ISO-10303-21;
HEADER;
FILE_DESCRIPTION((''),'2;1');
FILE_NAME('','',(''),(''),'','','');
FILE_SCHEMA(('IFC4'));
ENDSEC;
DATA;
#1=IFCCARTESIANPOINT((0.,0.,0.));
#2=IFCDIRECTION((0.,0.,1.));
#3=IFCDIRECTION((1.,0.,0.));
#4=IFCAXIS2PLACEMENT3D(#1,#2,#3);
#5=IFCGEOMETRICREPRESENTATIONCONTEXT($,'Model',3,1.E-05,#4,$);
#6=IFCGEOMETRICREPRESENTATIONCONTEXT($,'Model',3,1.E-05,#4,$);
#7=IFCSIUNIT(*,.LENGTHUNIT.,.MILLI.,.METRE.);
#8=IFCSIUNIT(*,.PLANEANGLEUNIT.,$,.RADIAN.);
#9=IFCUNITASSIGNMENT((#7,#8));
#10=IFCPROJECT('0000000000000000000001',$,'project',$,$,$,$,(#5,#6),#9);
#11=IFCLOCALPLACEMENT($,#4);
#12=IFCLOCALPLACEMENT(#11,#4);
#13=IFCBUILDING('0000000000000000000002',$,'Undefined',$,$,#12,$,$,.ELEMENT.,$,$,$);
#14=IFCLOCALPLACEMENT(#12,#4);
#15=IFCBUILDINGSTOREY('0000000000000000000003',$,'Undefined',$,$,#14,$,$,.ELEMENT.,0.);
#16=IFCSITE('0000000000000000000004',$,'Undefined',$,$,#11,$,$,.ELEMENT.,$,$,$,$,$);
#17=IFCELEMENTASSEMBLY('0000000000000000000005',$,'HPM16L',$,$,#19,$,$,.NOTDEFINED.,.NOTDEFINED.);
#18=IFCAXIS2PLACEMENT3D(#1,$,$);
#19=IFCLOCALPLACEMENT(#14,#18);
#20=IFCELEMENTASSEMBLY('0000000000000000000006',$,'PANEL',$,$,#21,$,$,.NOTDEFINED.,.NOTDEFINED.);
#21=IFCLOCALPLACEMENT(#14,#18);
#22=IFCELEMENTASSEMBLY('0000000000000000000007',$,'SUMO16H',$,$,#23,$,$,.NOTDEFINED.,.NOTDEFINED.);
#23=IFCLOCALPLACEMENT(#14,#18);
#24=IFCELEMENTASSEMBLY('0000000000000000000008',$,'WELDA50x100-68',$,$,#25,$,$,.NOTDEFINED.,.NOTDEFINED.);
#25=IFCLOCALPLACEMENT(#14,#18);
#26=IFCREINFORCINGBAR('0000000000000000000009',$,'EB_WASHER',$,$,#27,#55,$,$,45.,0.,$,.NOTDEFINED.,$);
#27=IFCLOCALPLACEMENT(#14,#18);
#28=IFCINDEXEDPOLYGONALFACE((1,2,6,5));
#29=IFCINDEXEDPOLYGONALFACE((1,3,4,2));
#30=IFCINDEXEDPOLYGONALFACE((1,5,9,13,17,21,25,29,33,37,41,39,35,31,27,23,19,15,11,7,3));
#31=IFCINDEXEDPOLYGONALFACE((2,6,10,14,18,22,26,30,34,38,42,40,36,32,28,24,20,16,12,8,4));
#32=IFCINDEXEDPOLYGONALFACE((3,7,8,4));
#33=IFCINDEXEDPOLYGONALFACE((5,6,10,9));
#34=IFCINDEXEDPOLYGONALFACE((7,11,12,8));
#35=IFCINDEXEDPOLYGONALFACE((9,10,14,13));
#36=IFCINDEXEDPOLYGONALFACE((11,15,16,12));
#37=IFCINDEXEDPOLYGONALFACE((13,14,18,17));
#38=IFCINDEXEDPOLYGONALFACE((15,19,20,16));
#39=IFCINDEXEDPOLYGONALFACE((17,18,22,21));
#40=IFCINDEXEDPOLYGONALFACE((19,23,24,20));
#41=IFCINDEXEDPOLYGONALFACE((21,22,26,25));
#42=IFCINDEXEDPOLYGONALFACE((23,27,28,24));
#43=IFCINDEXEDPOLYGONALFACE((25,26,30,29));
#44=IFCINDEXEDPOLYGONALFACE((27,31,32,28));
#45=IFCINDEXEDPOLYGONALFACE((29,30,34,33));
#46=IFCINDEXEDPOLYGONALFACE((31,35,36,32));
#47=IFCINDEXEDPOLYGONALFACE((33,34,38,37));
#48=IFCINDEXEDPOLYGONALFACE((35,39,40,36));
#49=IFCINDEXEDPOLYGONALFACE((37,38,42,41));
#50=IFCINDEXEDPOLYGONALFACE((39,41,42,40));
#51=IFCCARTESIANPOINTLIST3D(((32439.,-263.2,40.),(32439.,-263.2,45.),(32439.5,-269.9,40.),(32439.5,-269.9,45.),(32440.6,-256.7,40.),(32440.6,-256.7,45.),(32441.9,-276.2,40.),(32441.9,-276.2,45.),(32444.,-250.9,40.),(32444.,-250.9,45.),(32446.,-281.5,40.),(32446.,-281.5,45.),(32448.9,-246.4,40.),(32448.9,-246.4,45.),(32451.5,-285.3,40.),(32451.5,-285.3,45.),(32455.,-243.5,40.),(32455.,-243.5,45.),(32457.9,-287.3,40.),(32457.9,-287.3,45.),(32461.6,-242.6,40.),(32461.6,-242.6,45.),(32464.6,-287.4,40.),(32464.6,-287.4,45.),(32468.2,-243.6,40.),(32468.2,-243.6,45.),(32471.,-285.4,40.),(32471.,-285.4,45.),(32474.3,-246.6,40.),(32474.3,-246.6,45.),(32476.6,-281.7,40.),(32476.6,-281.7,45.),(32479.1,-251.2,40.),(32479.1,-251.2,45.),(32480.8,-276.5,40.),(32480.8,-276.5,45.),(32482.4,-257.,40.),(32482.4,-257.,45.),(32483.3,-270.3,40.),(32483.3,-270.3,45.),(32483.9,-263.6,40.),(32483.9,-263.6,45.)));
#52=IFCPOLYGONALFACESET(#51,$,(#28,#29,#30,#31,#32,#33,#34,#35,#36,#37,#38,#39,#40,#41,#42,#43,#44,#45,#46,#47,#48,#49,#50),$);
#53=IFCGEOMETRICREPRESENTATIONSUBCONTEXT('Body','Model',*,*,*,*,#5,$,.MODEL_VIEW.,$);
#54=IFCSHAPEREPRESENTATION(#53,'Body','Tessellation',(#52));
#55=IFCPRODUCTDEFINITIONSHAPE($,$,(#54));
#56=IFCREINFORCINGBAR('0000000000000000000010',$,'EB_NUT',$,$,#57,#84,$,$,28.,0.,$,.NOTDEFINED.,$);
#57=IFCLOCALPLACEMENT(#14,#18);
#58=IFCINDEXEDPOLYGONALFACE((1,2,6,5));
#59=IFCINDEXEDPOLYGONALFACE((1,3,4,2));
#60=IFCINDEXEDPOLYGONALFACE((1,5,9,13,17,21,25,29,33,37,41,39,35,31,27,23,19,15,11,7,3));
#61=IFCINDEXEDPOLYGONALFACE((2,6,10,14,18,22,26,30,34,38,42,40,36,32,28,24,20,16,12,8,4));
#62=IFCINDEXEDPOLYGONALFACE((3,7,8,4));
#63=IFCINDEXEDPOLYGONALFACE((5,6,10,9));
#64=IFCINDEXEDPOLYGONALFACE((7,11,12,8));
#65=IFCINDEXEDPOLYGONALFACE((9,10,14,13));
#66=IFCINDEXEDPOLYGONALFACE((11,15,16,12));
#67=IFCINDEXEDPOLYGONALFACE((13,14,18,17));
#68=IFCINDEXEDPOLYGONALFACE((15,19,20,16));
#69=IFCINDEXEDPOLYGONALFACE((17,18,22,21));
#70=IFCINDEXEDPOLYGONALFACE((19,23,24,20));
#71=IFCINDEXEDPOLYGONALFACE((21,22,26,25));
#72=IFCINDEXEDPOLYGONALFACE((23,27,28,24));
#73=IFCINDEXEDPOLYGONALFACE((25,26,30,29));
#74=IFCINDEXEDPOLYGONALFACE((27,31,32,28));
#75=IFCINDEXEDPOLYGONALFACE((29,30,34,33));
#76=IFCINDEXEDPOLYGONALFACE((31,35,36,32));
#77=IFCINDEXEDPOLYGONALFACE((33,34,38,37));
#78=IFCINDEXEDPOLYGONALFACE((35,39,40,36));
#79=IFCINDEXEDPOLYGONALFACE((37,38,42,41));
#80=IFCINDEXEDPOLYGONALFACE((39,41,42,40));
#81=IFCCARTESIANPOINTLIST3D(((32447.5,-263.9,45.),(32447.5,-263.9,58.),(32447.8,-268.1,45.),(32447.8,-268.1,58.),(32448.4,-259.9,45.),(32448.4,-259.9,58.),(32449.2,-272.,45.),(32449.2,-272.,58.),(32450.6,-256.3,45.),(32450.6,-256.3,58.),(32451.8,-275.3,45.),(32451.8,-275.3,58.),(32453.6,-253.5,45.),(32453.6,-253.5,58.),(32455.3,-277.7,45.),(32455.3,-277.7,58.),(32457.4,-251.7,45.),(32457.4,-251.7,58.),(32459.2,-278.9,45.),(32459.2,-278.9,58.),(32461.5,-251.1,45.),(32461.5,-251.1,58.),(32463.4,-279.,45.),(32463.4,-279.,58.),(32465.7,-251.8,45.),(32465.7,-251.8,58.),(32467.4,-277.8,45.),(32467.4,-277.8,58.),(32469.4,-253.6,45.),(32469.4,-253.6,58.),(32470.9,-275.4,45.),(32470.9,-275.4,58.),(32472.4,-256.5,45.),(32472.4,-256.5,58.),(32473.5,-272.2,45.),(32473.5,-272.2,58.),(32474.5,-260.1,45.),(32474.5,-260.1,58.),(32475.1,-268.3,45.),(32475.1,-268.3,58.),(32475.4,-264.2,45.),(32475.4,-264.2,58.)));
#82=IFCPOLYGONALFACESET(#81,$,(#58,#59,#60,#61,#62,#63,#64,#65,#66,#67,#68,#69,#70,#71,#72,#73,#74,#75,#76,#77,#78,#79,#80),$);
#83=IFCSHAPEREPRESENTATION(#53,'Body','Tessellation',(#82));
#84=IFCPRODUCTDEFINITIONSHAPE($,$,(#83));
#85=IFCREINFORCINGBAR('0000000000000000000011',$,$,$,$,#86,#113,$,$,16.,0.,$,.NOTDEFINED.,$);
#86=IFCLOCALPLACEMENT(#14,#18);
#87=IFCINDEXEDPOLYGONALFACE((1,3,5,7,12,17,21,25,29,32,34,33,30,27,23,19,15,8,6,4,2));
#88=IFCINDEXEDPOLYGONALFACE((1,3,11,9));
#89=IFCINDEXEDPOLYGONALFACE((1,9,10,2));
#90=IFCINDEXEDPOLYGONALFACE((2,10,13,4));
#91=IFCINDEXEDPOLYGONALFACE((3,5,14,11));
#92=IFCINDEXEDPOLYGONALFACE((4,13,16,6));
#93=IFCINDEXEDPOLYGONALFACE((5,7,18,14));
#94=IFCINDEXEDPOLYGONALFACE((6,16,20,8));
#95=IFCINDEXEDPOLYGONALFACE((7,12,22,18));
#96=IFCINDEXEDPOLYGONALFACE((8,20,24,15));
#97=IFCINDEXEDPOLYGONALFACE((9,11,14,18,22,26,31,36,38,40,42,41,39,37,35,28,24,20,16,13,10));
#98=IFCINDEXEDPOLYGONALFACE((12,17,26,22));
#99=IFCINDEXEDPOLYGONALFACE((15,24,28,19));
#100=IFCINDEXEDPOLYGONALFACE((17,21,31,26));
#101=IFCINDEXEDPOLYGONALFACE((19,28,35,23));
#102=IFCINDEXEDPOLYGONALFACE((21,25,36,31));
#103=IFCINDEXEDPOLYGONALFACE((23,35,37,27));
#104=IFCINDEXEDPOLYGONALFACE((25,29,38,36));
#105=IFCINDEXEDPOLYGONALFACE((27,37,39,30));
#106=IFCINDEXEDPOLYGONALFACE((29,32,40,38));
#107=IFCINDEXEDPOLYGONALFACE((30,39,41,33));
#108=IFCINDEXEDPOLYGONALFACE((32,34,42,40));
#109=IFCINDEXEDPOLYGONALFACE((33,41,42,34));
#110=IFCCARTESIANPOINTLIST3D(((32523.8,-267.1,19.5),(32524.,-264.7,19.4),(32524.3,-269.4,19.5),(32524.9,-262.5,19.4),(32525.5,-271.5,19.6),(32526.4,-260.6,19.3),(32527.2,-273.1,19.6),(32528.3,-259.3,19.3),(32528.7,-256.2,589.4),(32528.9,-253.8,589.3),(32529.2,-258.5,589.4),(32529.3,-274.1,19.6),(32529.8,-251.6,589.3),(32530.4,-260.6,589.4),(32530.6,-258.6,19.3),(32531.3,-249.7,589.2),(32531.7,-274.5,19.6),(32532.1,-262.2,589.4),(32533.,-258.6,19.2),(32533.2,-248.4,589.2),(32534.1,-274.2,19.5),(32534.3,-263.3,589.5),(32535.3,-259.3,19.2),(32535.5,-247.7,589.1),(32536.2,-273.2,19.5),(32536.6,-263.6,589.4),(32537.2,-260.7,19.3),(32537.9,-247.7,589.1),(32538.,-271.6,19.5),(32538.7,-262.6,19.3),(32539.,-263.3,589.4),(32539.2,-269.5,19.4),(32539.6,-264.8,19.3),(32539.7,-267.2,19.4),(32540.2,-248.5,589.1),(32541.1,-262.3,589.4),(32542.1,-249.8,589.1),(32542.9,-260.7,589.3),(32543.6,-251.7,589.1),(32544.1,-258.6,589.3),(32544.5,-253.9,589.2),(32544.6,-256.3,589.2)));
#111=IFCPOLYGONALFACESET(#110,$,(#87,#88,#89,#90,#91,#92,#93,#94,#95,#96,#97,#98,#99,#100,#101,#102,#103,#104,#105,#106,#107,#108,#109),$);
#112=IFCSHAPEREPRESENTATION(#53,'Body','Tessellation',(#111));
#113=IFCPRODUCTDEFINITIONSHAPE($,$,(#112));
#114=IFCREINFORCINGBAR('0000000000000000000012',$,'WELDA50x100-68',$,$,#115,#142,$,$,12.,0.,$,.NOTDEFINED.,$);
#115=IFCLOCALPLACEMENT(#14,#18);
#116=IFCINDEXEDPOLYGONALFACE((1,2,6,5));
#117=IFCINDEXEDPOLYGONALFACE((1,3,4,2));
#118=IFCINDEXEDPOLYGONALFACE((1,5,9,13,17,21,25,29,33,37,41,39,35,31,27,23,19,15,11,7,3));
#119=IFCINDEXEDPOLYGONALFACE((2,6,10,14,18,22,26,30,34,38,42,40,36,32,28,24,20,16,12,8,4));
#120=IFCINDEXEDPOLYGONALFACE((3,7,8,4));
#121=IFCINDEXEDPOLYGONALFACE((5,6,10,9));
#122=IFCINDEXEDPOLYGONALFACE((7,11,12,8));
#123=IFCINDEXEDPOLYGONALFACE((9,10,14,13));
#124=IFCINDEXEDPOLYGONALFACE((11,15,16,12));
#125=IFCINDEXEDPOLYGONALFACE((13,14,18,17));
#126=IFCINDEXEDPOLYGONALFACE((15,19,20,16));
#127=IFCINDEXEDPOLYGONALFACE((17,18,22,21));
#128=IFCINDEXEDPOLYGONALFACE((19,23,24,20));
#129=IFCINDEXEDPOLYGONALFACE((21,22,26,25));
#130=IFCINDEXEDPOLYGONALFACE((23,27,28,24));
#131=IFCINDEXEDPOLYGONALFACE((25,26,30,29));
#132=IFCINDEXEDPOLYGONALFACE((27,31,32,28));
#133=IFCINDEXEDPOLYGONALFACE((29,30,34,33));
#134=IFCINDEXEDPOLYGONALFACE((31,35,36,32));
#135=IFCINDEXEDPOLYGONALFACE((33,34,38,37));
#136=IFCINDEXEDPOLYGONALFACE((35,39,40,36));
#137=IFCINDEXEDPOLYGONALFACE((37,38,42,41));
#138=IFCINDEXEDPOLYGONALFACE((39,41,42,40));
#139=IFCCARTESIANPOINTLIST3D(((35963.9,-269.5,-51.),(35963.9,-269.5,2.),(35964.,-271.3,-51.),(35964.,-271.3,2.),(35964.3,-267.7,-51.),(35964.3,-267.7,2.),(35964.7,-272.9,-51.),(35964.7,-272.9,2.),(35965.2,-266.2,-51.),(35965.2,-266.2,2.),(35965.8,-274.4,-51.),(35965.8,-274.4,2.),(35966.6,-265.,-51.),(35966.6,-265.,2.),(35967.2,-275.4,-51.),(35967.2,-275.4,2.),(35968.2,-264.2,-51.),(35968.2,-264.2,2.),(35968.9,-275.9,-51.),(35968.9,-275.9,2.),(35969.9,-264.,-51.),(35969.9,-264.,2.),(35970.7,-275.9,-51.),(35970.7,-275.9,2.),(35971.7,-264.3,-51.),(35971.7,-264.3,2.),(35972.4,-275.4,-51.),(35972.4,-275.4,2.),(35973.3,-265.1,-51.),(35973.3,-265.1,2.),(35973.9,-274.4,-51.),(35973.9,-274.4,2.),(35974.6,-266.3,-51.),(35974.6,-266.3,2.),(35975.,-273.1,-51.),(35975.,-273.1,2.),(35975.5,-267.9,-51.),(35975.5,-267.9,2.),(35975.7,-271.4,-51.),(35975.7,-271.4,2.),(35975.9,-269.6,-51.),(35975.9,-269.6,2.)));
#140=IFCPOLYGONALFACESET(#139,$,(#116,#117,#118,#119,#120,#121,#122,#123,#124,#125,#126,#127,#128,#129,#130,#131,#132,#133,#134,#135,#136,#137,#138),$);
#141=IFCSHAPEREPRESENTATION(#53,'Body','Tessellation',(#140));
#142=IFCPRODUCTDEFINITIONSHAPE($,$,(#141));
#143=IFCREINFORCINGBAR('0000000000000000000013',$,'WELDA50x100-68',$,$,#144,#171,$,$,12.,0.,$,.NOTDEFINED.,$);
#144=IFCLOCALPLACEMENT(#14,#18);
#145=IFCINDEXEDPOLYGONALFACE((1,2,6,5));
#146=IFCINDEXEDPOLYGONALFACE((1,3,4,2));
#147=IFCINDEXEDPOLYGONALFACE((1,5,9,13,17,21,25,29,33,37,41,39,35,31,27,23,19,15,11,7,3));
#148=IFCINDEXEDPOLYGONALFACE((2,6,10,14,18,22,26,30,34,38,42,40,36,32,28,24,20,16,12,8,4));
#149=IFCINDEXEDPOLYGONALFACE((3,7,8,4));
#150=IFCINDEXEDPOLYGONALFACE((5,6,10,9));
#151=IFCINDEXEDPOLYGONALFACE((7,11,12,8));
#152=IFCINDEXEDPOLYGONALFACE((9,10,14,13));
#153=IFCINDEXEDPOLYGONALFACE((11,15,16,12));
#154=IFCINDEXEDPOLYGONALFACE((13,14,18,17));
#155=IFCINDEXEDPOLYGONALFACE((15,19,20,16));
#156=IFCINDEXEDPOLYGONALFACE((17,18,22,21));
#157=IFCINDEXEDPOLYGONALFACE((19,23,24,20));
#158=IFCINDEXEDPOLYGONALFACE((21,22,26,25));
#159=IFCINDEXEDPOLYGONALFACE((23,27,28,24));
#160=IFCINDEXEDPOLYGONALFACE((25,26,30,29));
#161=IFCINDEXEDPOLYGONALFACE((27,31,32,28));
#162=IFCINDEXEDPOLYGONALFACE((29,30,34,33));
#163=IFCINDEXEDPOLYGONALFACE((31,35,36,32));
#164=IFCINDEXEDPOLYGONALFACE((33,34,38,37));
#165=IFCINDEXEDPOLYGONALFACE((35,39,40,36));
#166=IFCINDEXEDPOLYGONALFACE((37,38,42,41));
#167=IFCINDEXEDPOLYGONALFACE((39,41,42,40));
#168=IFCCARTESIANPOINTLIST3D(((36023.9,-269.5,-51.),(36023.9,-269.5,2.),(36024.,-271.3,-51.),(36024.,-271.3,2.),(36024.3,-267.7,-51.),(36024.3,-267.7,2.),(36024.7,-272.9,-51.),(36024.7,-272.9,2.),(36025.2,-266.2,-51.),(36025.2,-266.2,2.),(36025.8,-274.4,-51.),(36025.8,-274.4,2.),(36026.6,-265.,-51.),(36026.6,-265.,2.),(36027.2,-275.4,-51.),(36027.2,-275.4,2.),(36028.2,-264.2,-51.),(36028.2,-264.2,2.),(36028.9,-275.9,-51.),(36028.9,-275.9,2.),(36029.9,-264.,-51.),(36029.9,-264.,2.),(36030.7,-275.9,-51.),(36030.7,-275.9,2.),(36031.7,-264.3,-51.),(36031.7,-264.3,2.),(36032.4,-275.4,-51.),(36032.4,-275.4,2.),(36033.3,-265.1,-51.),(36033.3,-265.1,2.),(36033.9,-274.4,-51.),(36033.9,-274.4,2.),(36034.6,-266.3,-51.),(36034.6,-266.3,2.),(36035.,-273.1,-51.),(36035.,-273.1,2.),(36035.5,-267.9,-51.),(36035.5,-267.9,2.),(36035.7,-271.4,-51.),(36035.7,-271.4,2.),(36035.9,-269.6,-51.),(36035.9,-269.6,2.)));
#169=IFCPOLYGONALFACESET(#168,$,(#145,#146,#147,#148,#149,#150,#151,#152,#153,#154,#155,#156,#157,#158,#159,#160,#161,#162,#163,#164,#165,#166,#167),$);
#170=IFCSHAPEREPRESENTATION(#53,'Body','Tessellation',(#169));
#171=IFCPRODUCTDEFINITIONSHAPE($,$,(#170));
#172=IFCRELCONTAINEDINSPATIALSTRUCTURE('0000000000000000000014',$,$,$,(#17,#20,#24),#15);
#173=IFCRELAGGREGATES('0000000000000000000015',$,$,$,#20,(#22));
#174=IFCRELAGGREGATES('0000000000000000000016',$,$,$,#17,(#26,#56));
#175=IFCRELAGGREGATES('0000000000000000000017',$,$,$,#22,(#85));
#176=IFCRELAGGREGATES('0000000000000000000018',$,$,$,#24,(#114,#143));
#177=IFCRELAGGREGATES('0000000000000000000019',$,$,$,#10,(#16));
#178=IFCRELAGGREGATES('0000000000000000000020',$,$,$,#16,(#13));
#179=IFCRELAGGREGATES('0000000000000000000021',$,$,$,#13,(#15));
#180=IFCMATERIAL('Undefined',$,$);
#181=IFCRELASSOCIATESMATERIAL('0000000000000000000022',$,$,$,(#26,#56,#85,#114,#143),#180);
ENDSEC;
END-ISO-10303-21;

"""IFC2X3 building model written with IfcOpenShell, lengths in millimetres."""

from ifc_helpers import new_model, entity, si_unit, frame, origin_with_axes, place, context, subcontext, project, spatial, source, transform, mapped, material, element, aggregate, save


model = new_model("IFC2X3")

# Units and contexts
model_context_1 = context("Model", 3, precision=1e-05, world=origin_with_axes())
model_context_2 = context("Model", 3, precision=1e-05, world=origin_with_axes())
body_context = subcontext(model_context_1, "Body", "Model", "MODEL_VIEW")
ifc_project = project(units=[si_unit("LENGTHUNIT", "METRE", prefix="MILLI"), si_unit("PLANEANGLEUNIT", "RADIAN")], contexts=[model_context_1, model_context_2])

# Site, building, storey
site_placement = place(None, origin_with_axes())
site = spatial("IfcSite", under=ifc_project, at=site_placement, Name="Undefined", CompositionType="ELEMENT")
building_placement = place(site_placement, origin_with_axes())
building = spatial("IfcBuilding", under=site, at=building_placement, Name="Undefined", CompositionType="ELEMENT")
storey_placement = place(building_placement, origin_with_axes())
storey = spatial("IfcBuildingStorey", under=building, at=storey_placement, Name="Undefined", CompositionType="ELEMENT", Elevation=0.0)

# Element assembly
assembly_1_placement = place(storey_placement, origin_with_axes())
assembly_1 = element("IfcElementAssembly", 1, at=assembly_1_placement, inside=storey, Name="HPM16L", AssemblyPlace="NOTDEFINED", PredefinedType="NOTDEFINED")

# Element assemblies
assembly_2_placement = place(storey_placement, origin_with_axes())
assembly_2 = element("IfcElementAssembly", 2, at=assembly_2_placement, inside=storey, Name="PANEL", AssemblyPlace="NOTDEFINED", PredefinedType="NOTDEFINED")
assembly_3_placement = place(assembly_2_placement, origin_with_axes())
assembly_3 = element("IfcElementAssembly", 3, at=assembly_3_placement, Name="SUMO16H", AssemblyPlace="NOTDEFINED", PredefinedType="NOTDEFINED")
aggregate(assembly_2, [assembly_3])

# Element assembly
assembly_4_placement = place(storey_placement, origin_with_axes())
assembly_4 = element("IfcElementAssembly", 4, at=assembly_4_placement, inside=storey, Name="WELDA50x100-68", AssemblyPlace="NOTDEFINED", PredefinedType="NOTDEFINED")

# Reinforcing bars
ifc_material_1 = material(Name="Undefined")
shared_shape_1 = source(origin_with_axes(), body_context, "Body", "AdvancedSweptSolid", [
    entity("IfcSweptDiskSolid", entity("IfcTrimmedCurve", entity("IfcLine", entity("IfcCartesianPoint", [0.0, 0.0, 0.0]), entity("IfcVector", entity("IfcDirection", [1.0, 0.0, 0.0]), 1.0)), [entity("IfcParameterValue", 0.0)], [entity("IfcParameterValue", 5.0)], True, "PARAMETER"), 22.5, None, 0.0, 5.0),
])
reinforcing_bar_1_placement = place(assembly_1_placement, frame((32461.4, -265.1, 45.0), z_axis=(0.008166, 0.999967, 0.0), x_axis=(0.0, 0.0, -1.0)))
reinforcing_bar_1 = element("IfcReinforcingBar", 5, at=reinforcing_bar_1_placement, material=ifc_material_1, Name="EB_WASHER", BarRole="NOTDEFINED", CrossSectionArea=0.0, NominalDiameter=45.0, context=body_context, shape_type="MappedRepresentation", body=[
    mapped(shared_shape_1, transform((0.0, 0.0, 0.0))),
])
shared_shape_2 = source(origin_with_axes(), body_context, "Body", "AdvancedSweptSolid", [
    entity("IfcSweptDiskSolid", entity("IfcTrimmedCurve", entity("IfcLine", entity("IfcCartesianPoint", [0.0, 0.0, 0.0]), entity("IfcVector", entity("IfcDirection", [1.0, 0.0, 0.0]), 1.0)), [entity("IfcParameterValue", 0.0)], [entity("IfcParameterValue", 13.0)], True, "PARAMETER"), 14.0, None, 0.0, 13.0),
])
reinforcing_bar_2_placement = place(assembly_1_placement, frame((32461.4, -265.1, 58.0), z_axis=(0.008166, 0.999967, 0.0), x_axis=(0.0, 0.0, -1.0)))
reinforcing_bar_2 = element("IfcReinforcingBar", 6, at=reinforcing_bar_2_placement, material=ifc_material_1, Name="EB_NUT", BarRole="NOTDEFINED", CrossSectionArea=0.0, NominalDiameter=28.0, context=body_context, shape_type="MappedRepresentation", body=[
    mapped(shared_shape_2, transform((0.0, 0.0, 0.0))),
])
aggregate(assembly_1, [reinforcing_bar_1, reinforcing_bar_2])
shared_shape_3 = source(origin_with_axes(), body_context, "Body", "AdvancedSweptSolid", [
    entity("IfcSweptDiskSolid", entity("IfcTrimmedCurve", entity("IfcLine", entity("IfcCartesianPoint", [0.0, 0.0, 0.0]), entity("IfcVector", entity("IfcDirection", [1.0, 0.0, 0.0]), 1.0)), [entity("IfcParameterValue", 0.0)], [entity("IfcParameterValue", 570.0)], True, "PARAMETER"), 8.0, None, 0.0, 570.0),
])
reinforcing_bar_3_placement = place(assembly_3_placement, frame((32531.8, -266.5, 19.4), z_axis=(-0.006955, -0.999792, 0.019153), x_axis=(0.008618, 0.019092, 0.999781)))
reinforcing_bar_3 = element("IfcReinforcingBar", 7, at=reinforcing_bar_3_placement, material=ifc_material_1, BarRole="NOTDEFINED", CrossSectionArea=0.0, NominalDiameter=16.0, context=body_context, shape_type="MappedRepresentation", body=[
    mapped(shared_shape_3, transform((0.0, 0.0, 0.0))),
])
aggregate(assembly_3, [reinforcing_bar_3])
shared_shape_4 = source(origin_with_axes(), body_context, "Body", "AdvancedSweptSolid", [
    entity("IfcSweptDiskSolid", entity("IfcTrimmedCurve", entity("IfcLine", entity("IfcCartesianPoint", [0.0, 0.0, 0.0]), entity("IfcVector", entity("IfcDirection", [1.0, 0.0, 0.0]), 1.0)), [entity("IfcParameterValue", 0.0)], [entity("IfcParameterValue", 53.0)], True, "PARAMETER"), 6.0, None, 0.0, 53.0),
])
reinforcing_bar_4_placement = place(assembly_4_placement, frame((35969.9, -270.0, 2.0), z_axis=(0.011111, 0.999938, 0.0), x_axis=(0.0, 0.0, -1.0)))
reinforcing_bar_4 = element("IfcReinforcingBar", 8, at=reinforcing_bar_4_placement, material=ifc_material_1, Name="WELDA50x100-68", BarRole="NOTDEFINED", CrossSectionArea=0.0, NominalDiameter=12.0, context=body_context, shape_type="MappedRepresentation", body=[
    mapped(shared_shape_4, transform((0.0, 0.0, 0.0))),
])
shared_shape_5 = source(origin_with_axes(), body_context, "Body", "AdvancedSweptSolid", [
    entity("IfcSweptDiskSolid", entity("IfcTrimmedCurve", entity("IfcLine", entity("IfcCartesianPoint", [0.0, 0.0, 0.0]), entity("IfcVector", entity("IfcDirection", [1.0, 0.0, 0.0]), 1.0)), [entity("IfcParameterValue", 0.0)], [entity("IfcParameterValue", 53.0)], True, "PARAMETER"), 6.0, None, 0.0, 53.0),
])
reinforcing_bar_5_placement = place(assembly_4_placement, frame((36029.9, -270.0, 2.0), z_axis=(0.011111, 0.999938, 0.0), x_axis=(0.0, 0.0, -1.0)))
reinforcing_bar_5 = element("IfcReinforcingBar", 9, at=reinforcing_bar_5_placement, material=ifc_material_1, Name="WELDA50x100-68", BarRole="NOTDEFINED", CrossSectionArea=0.0, NominalDiameter=12.0, context=body_context, shape_type="MappedRepresentation", body=[
    mapped(shared_shape_5, transform((0.0, 0.0, 0.0))),
])
aggregate(assembly_4, [reinforcing_bar_4, reinforcing_bar_5])

save(model, "model.ifc")
